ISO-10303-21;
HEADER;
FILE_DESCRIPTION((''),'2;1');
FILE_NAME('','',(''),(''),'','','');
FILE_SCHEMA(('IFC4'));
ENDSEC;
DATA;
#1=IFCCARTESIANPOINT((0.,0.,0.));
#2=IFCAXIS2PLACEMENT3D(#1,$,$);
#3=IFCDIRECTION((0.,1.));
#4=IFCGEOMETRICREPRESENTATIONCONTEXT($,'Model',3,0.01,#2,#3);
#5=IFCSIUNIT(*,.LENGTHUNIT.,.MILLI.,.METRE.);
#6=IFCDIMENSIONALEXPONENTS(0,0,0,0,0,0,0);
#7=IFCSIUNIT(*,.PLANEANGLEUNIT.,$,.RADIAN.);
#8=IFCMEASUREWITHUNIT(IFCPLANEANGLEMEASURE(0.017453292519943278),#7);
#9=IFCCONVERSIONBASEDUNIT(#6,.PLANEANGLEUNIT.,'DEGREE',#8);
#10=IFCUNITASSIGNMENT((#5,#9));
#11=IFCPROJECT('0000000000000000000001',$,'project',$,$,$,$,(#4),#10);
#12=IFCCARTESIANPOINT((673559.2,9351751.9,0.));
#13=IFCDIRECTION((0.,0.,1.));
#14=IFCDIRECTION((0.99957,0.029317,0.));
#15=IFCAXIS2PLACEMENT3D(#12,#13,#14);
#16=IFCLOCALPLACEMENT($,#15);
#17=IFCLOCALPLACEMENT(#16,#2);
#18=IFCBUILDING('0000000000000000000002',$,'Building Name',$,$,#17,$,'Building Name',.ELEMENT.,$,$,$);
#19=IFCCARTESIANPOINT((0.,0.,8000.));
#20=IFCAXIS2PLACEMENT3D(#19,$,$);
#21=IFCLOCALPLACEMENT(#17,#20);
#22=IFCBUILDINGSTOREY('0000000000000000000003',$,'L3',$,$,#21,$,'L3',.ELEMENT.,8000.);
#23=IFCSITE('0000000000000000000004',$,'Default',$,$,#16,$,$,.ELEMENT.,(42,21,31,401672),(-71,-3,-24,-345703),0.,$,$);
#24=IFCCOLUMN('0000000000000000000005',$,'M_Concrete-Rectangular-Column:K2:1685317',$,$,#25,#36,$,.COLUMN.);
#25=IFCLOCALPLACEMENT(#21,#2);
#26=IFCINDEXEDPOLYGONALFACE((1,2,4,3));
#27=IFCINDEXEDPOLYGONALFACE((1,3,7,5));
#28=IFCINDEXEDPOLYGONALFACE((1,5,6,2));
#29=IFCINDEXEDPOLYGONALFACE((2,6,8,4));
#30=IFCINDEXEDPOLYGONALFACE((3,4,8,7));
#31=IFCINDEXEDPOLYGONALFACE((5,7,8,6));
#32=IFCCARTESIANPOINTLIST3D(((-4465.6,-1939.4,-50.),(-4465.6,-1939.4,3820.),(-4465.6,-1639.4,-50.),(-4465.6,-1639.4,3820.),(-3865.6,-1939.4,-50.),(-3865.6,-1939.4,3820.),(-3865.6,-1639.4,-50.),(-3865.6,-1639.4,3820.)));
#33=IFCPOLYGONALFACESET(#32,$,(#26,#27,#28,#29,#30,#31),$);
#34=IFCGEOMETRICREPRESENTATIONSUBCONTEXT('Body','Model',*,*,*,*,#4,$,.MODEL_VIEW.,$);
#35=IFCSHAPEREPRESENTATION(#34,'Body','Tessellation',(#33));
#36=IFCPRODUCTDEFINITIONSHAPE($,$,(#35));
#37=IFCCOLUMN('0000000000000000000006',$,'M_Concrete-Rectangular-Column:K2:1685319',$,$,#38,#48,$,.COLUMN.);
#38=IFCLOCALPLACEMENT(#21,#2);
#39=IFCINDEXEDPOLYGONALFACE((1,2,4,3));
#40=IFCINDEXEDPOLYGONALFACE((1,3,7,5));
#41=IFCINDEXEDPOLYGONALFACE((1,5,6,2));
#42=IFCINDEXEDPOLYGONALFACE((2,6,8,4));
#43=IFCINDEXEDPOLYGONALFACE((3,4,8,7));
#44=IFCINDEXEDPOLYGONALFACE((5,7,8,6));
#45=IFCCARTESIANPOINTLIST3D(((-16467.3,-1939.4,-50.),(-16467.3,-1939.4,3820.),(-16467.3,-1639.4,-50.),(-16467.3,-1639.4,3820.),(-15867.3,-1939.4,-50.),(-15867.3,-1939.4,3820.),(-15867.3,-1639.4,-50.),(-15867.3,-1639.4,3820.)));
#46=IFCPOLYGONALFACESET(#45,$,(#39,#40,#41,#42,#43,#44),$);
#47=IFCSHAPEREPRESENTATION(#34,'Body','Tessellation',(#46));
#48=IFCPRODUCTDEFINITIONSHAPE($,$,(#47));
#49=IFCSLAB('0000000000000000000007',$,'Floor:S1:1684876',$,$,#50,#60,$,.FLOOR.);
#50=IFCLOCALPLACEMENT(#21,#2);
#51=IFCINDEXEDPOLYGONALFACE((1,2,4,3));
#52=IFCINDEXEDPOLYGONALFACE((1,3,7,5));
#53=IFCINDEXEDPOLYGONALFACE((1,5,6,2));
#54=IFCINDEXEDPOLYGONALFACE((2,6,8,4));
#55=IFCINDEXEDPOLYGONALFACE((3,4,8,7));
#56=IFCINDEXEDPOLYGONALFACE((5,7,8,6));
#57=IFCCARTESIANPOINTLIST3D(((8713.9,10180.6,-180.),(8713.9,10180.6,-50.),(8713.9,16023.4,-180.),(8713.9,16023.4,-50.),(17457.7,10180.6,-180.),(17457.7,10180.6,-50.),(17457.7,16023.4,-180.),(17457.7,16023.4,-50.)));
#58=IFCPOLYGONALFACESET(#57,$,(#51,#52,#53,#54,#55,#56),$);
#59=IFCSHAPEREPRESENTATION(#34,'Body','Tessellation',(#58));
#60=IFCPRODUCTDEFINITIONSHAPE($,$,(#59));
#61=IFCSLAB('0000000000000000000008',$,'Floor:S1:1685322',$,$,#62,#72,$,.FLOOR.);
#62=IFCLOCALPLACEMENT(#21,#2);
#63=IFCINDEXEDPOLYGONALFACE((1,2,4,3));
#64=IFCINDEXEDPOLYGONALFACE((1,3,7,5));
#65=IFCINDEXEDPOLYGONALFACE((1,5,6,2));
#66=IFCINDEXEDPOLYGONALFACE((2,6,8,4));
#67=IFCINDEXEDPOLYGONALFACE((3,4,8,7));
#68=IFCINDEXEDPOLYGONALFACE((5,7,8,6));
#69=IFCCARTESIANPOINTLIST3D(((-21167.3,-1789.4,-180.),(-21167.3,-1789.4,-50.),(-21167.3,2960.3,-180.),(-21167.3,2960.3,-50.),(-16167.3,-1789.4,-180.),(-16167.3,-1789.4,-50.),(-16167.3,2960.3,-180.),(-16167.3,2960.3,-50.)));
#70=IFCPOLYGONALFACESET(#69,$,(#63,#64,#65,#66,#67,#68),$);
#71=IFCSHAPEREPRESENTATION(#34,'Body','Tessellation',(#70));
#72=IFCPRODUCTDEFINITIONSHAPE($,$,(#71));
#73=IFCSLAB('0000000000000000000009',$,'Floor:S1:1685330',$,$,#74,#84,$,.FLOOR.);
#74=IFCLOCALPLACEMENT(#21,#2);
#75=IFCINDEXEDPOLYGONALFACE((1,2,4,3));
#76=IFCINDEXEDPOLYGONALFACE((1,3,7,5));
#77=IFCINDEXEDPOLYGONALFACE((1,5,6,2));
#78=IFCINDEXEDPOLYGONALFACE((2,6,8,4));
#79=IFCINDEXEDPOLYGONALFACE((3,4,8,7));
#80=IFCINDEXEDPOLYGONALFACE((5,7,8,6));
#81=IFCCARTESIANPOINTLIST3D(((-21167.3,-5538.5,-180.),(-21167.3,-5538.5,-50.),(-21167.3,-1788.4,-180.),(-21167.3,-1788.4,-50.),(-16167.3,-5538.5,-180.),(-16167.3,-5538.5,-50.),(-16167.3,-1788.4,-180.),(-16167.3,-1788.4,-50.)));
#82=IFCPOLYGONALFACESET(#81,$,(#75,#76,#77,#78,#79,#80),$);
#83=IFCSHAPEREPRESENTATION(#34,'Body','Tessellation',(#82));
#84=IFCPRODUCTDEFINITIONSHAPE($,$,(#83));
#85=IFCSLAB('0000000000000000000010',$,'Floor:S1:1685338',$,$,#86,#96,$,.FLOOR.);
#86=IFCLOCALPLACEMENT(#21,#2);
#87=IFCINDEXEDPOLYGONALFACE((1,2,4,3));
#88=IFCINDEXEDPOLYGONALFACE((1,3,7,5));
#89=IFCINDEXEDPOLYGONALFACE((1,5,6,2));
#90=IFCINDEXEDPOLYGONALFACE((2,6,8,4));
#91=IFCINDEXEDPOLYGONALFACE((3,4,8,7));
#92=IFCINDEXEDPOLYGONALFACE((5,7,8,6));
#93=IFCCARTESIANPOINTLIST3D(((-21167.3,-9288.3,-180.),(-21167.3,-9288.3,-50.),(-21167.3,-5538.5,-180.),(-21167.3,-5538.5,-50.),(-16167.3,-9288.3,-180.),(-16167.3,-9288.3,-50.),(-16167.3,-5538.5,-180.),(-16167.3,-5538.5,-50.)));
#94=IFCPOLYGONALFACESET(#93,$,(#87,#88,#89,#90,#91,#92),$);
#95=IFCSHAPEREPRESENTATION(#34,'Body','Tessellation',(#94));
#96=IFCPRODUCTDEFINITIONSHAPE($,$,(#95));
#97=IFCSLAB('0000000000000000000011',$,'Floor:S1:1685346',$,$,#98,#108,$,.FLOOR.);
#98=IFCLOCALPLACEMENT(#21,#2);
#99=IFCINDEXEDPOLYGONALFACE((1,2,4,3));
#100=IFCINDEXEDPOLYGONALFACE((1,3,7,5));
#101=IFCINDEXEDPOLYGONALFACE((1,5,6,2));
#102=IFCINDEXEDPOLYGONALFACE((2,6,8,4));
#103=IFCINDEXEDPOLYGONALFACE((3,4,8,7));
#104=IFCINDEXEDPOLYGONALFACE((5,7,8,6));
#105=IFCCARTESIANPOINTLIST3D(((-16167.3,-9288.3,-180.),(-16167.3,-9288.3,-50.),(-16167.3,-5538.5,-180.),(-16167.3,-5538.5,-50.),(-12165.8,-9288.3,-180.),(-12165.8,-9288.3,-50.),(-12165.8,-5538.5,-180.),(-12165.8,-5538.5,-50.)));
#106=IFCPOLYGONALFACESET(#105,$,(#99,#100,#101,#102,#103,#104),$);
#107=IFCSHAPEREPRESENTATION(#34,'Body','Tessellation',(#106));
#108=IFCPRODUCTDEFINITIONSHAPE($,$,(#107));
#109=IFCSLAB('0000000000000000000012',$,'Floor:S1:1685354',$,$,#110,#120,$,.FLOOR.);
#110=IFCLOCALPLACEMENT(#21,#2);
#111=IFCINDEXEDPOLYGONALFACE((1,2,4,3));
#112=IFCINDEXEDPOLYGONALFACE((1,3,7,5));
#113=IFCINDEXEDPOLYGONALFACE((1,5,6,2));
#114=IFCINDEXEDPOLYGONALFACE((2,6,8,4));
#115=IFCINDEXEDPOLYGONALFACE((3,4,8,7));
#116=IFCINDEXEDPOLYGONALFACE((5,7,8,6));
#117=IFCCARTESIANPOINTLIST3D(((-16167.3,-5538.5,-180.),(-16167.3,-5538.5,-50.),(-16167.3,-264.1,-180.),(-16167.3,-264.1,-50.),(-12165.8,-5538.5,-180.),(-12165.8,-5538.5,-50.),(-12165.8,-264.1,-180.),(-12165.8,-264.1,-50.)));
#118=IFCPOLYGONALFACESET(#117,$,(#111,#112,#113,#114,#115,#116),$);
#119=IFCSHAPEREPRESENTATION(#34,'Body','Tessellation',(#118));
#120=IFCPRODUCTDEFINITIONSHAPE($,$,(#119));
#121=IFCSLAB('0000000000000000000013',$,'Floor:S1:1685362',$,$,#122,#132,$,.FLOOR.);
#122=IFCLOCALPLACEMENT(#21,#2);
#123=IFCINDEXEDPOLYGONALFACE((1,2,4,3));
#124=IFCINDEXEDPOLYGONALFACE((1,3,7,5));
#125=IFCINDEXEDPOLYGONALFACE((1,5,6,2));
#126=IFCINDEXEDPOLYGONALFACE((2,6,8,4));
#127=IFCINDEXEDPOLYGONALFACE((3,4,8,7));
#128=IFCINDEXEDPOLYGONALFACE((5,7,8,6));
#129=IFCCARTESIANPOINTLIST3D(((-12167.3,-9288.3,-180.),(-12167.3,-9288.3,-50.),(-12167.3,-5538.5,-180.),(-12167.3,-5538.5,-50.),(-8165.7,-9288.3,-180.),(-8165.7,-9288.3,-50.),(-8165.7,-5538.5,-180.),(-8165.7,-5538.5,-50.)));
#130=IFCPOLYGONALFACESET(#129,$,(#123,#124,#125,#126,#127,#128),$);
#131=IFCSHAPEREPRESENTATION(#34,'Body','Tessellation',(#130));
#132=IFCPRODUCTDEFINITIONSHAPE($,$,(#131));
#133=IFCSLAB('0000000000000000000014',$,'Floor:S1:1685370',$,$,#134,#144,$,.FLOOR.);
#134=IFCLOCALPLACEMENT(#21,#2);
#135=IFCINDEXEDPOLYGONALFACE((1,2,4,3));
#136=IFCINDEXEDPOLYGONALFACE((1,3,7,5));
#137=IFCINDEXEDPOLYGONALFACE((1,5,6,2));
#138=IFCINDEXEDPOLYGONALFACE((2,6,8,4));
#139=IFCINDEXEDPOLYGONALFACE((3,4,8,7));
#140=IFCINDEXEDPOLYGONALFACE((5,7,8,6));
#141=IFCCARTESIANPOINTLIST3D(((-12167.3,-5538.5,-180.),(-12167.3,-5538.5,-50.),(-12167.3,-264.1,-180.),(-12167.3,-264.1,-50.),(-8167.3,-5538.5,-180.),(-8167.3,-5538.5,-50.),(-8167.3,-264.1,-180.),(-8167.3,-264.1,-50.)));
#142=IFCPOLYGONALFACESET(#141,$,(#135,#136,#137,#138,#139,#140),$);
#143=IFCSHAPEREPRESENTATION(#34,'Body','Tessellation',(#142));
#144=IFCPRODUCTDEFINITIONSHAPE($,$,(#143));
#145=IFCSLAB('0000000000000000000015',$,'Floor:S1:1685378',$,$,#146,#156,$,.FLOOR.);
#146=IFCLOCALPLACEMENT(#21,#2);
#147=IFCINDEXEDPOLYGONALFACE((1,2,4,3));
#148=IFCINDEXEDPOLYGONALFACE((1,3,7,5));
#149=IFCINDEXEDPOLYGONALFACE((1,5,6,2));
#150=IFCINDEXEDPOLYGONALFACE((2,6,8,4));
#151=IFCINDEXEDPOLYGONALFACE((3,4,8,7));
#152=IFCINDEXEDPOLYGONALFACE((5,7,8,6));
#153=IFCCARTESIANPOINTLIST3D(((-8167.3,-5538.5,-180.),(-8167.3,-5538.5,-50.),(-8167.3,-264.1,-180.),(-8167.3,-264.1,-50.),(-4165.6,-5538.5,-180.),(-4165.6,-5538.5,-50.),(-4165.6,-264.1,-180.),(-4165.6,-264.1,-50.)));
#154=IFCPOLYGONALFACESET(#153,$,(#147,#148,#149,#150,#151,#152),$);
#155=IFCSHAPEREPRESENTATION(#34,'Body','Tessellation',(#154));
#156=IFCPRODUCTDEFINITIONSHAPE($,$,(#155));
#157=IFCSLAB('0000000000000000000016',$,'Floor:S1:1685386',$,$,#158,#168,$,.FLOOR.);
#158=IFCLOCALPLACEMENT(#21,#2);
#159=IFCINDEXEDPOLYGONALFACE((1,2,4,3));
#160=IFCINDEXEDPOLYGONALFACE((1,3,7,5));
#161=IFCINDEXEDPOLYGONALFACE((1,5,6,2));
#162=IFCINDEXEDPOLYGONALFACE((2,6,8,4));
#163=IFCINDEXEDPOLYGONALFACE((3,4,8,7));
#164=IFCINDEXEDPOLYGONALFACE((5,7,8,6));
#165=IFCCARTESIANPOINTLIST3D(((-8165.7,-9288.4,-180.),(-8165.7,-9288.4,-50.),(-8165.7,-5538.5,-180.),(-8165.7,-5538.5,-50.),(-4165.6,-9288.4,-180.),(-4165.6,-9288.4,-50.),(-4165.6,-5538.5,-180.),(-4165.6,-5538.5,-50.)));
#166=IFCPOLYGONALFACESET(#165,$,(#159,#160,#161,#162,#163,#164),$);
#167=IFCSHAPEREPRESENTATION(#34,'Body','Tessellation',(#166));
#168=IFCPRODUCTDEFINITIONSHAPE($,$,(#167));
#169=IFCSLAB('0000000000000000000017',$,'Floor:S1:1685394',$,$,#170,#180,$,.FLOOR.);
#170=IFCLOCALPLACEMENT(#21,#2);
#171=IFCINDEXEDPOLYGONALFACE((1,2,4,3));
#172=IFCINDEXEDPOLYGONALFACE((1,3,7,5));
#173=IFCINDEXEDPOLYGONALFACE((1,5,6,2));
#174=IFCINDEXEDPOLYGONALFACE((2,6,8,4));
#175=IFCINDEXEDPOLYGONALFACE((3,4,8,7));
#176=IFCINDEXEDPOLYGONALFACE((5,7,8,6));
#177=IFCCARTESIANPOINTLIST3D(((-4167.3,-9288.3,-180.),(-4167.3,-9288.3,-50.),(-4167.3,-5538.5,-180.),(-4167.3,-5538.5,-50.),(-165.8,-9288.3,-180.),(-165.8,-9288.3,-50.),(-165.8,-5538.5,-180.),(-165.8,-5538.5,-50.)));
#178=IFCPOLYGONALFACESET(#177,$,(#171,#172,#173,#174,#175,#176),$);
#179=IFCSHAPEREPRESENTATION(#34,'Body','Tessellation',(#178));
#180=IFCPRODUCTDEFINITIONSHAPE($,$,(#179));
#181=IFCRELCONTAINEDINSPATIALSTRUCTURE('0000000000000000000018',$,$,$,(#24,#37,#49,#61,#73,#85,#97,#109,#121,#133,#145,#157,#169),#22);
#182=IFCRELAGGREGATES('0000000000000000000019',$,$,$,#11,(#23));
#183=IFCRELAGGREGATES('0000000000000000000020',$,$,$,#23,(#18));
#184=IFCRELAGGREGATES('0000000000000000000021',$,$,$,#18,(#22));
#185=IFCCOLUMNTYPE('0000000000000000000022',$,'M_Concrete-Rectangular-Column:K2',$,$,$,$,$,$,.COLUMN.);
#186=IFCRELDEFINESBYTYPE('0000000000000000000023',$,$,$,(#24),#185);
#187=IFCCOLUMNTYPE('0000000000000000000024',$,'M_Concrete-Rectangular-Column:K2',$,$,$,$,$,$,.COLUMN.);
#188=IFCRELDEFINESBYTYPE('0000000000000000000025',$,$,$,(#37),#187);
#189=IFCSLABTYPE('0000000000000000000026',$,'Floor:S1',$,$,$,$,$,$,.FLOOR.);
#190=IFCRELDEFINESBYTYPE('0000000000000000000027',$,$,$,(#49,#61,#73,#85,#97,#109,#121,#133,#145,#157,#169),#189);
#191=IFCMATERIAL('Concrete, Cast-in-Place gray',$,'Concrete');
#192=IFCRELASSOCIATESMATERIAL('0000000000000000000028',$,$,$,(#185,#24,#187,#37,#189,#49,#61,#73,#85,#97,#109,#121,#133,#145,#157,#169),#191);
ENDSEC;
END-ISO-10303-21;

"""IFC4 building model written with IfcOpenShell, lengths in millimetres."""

from ifc_helpers import new_model, entity, si_unit, converted_unit, direction, frame, origin, place, context, subcontext, project, spatial, indexed_curve, outline, extrude, source, transform, mapped, material, type_object, type_shapes, element, save


model = new_model("IFC4")

# Units and contexts
model_context = context("Model", 3, precision=0.01, world=origin(), true_north=direction((0.0, 1.0)))
body_context = subcontext(model_context, "Body", "Model", "MODEL_VIEW")
ifc_project = project(units=[si_unit("LENGTHUNIT", "METRE", prefix="MILLI"), converted_unit("PLANEANGLEUNIT", "DEGREE", entity("IfcPlaneAngleMeasure", 0.017453292519943278), si_unit("PLANEANGLEUNIT", "RADIAN"), dimensions=[0, 0, 0, 0, 0, 0, 0])], contexts=[model_context])

# Site, building, storey
site_placement = place(None, frame((673559.2, 9351751.9, 0.0), z_axis=(0.0, 0.0, 1.0), x_axis=(0.99957, 0.029317, 0.0)))
site = spatial("IfcSite", under=ifc_project, at=site_placement, Name="Default", CompositionType="ELEMENT", RefLatitude=(42, 21, 31, 401672), RefLongitude=(-71, -3, -24, -345703), RefElevation=0.0)
building_placement = place(site_placement, origin())
building = spatial("IfcBuilding", under=site, at=building_placement, Name="Building Name", LongName="Building Name", CompositionType="ELEMENT")
storey_placement = place(building_placement, frame((0.0, 0.0, 8000.0)))
storey = spatial("IfcBuildingStorey", under=building, at=storey_placement, Name="L3", LongName="L3", CompositionType="ELEMENT", Elevation=8000.0)

# Columns
ifc_material = material(Name="Concrete, Cast-in-Place gray", Category="Concrete")
column_type_1 = type_object("IfcColumnType", Name="M_Concrete-Rectangular-Column:K2", PredefinedType="COLUMN", material=ifc_material)
shared_shape_1 = source(origin(), body_context, "Body", "SweptSolid", [
    extrude(outline(indexed_curve([(-150.0, -300.0), (150.0, -300.0), (150.0, 300.0), (-150.0, 300.0), (-150.0, -300.0)], self_intersect=False)), frame((-4165.6, -1789.4, 7950.0), z_axis=(0.0, 0.0, 1.0), x_axis=(0.0, -1.0, 0.0)), (0.0, 0.0, 1.0), 3870.0),
])
type_shapes(column_type_1, [shared_shape_1])
column_1_placement = place(storey_placement, frame((0.0, 0.0, -8000.0)))
element("IfcColumn", 1, at=column_1_placement, inside=storey, type_object=column_type_1, material=ifc_material, Name="M_Concrete-Rectangular-Column:K2:1685317", PredefinedType="COLUMN", context=body_context, shape_type="MappedRepresentation", body=[
    mapped(shared_shape_1, transform((0.0, 0.0, 0.0), scale=1.0)),
])
column_type_2 = type_object("IfcColumnType", Name="M_Concrete-Rectangular-Column:K2", PredefinedType="COLUMN", material=ifc_material)
shared_shape_2 = source(origin(), body_context, "Body", "SweptSolid", [
    extrude(outline(indexed_curve([(-150.0, -300.0), (150.0, -300.0), (150.0, 300.0), (-150.0, 300.0), (-150.0, -300.0)], self_intersect=False)), frame((-16167.3, -1789.4, 7950.0), z_axis=(0.0, 0.0, 1.0), x_axis=(0.0, -1.0, 0.0)), (0.0, 0.0, 1.0), 3870.0),
])
type_shapes(column_type_2, [shared_shape_2])
column_2_placement = place(storey_placement, frame((0.0, 0.0, -8000.0)))
element("IfcColumn", 2, at=column_2_placement, inside=storey, type_object=column_type_2, material=ifc_material, Name="M_Concrete-Rectangular-Column:K2:1685319", PredefinedType="COLUMN", context=body_context, shape_type="MappedRepresentation", body=[
    mapped(shared_shape_2, transform((0.0, 0.0, 0.0), scale=1.0)),
])

# Slabs
slab_type_1 = type_object("IfcSlabType", Name="Floor:S1", PredefinedType="FLOOR", material=ifc_material)
slab_1_placement = place(storey_placement, origin())
element("IfcSlab", 3, at=slab_1_placement, inside=storey, type_object=slab_type_1, material=ifc_material, Name="Floor:S1:1684876", PredefinedType="FLOOR", context=body_context, shape_type="SweptSolid", body=[
    extrude(outline(indexed_curve([(-2921.4, -4371.9), (2921.4, -4371.9), (2921.4, 4371.9), (-2921.4, 4371.9), (-2921.4, -4371.9)], self_intersect=False)), frame((13085.8, 13102.0, -50.0), z_axis=(0.0, 0.0, -1.0), x_axis=(0.0, 1.0, 0.0)), (0.0, 0.0, 1.0), 130.0),
])
slab_2_placement = place(storey_placement, origin())
element("IfcSlab", 4, at=slab_2_placement, inside=storey, type_object=slab_type_1, material=ifc_material, Name="Floor:S1:1685322", PredefinedType="FLOOR", context=body_context, shape_type="SweptSolid", body=[
    extrude(outline(indexed_curve([(-2374.9, -2500.0), (2374.9, -2500.0), (2374.9, 2500.0), (-2374.9, 2500.0), (-2374.9, -2500.0)], self_intersect=False)), frame((-18667.3, 585.4, -50.0), z_axis=(0.0, 0.0, -1.0), x_axis=(0.0, 1.0, 0.0)), (0.0, 0.0, 1.0), 130.0),
])
slab_3_placement = place(storey_placement, origin())
element("IfcSlab", 5, at=slab_3_placement, inside=storey, type_object=slab_type_1, material=ifc_material, Name="Floor:S1:1685330", PredefinedType="FLOOR", context=body_context, shape_type="SweptSolid", body=[
    extrude(outline(indexed_curve([(-1875.1, -2500.0), (1875.1, -2500.0), (1875.1, 2500.0), (-1875.1, 2500.0), (-1875.1, -2500.0)], self_intersect=False)), frame((-18667.3, -3663.5, -50.0), z_axis=(0.0, 0.0, -1.0), x_axis=(0.0, 1.0, 0.0)), (0.0, 0.0, 1.0), 130.0),
])
slab_4_placement = place(storey_placement, origin())
element("IfcSlab", 6, at=slab_4_placement, inside=storey, type_object=slab_type_1, material=ifc_material, Name="Floor:S1:1685338", PredefinedType="FLOOR", context=body_context, shape_type="SweptSolid", body=[
    extrude(outline(indexed_curve([(-1874.9, -2500.0), (1874.9, -2500.0), (1874.9, 2500.0), (-1874.9, 2500.0), (-1874.9, -2500.0)], self_intersect=False)), frame((-18667.3, -7413.4, -50.0), z_axis=(0.0, 0.0, -1.0), x_axis=(0.0, 1.0, 0.0)), (0.0, 0.0, 1.0), 130.0),
])
slab_5_placement = place(storey_placement, origin())
element("IfcSlab", 7, at=slab_5_placement, inside=storey, type_object=slab_type_1, material=ifc_material, Name="Floor:S1:1685346", PredefinedType="FLOOR", context=body_context, shape_type="SweptSolid", body=[
    extrude(outline(indexed_curve([(-1874.9, -2000.8), (1874.9, -2000.8), (1874.9, 2000.8), (-1874.9, 2000.8), (-1874.9, -2000.8)], self_intersect=False)), frame((-14166.6, -7413.4, -50.0), z_axis=(0.0, 0.0, -1.0), x_axis=(0.0, 1.0, 0.0)), (0.0, 0.0, 1.0), 130.0),
])
slab_6_placement = place(storey_placement, origin())
element("IfcSlab", 8, at=slab_6_placement, inside=storey, type_object=slab_type_1, material=ifc_material, Name="Floor:S1:1685354", PredefinedType="FLOOR", context=body_context, shape_type="SweptSolid", body=[
    extrude(outline(indexed_curve([(-2637.2, -2000.8), (2637.2, -2000.8), (2637.2, 2000.8), (-2637.2, 2000.8), (-2637.2, -2000.8)], self_intersect=False)), frame((-14166.6, -2901.3, -50.0), z_axis=(0.0, 0.0, -1.0), x_axis=(0.0, 1.0, 0.0)), (0.0, 0.0, 1.0), 130.0),
])
slab_7_placement = place(storey_placement, origin())
element("IfcSlab", 9, at=slab_7_placement, inside=storey, type_object=slab_type_1, material=ifc_material, Name="Floor:S1:1685362", PredefinedType="FLOOR", context=body_context, shape_type="SweptSolid", body=[
    extrude(outline(indexed_curve([(-1874.9, -2000.8), (1874.9, -2000.8), (1874.9, 2000.8), (-1874.9, 2000.8), (-1874.9, -2000.8)], self_intersect=False)), frame((-10166.5, -7413.4, -50.0), z_axis=(0.0, 0.0, -1.0), x_axis=(0.0, 1.0, 0.0)), (0.0, 0.0, 1.0), 130.0),
])
slab_8_placement = place(storey_placement, origin())
element("IfcSlab", 10, at=slab_8_placement, inside=storey, type_object=slab_type_1, material=ifc_material, Name="Floor:S1:1685370", PredefinedType="FLOOR", context=body_context, shape_type="SweptSolid", body=[
    extrude(outline(indexed_curve([(-2637.2, -2000.0), (2637.2, -2000.0), (2637.2, 2000.0), (-2637.2, 2000.0), (-2637.2, -2000.0)], self_intersect=False)), frame((-10167.3, -2901.3, -50.0), z_axis=(0.0, 0.0, -1.0), x_axis=(0.0, 1.0, 0.0)), (0.0, 0.0, 1.0), 130.0),
])
slab_9_placement = place(storey_placement, origin())
element("IfcSlab", 11, at=slab_9_placement, inside=storey, type_object=slab_type_1, material=ifc_material, Name="Floor:S1:1685378", PredefinedType="FLOOR", context=body_context, shape_type="SweptSolid", body=[
    extrude(outline(indexed_curve([(-2637.2, -2000.9), (2637.2, -2000.9), (2637.2, 2000.9), (-2637.2, 2000.9), (-2637.2, -2000.9)], self_intersect=False)), frame((-6166.4, -2901.3, -50.0), z_axis=(0.0, 0.0, -1.0), x_axis=(0.0, 1.0, 0.0)), (0.0, 0.0, 1.0), 130.0),
])
slab_10_placement = place(storey_placement, origin())
element("IfcSlab", 12, at=slab_10_placement, inside=storey, type_object=slab_type_1, material=ifc_material, Name="Floor:S1:1685386", PredefinedType="FLOOR", context=body_context, shape_type="SweptSolid", body=[
    extrude(outline(indexed_curve([(-1874.9, -2000.1), (1874.9, -2000.1), (1874.9, 2000.1), (-1874.9, 2000.1), (-1874.9, -2000.1)], self_intersect=False)), frame((-6165.6, -7413.5, -50.0), z_axis=(0.0, 0.0, -1.0), x_axis=(0.0, 1.0, 0.0)), (0.0, 0.0, 1.0), 130.0),
])
slab_11_placement = place(storey_placement, origin())
element("IfcSlab", 13, at=slab_11_placement, inside=storey, type_object=slab_type_1, material=ifc_material, Name="Floor:S1:1685394", PredefinedType="FLOOR", context=body_context, shape_type="SweptSolid", body=[
    extrude(outline(indexed_curve([(-1874.9, -2000.8), (1874.9, -2000.8), (1874.9, 2000.8), (-1874.9, 2000.8), (-1874.9, -2000.8)], self_intersect=False)), frame((-2166.6, -7413.4, -50.0), z_axis=(0.0, 0.0, -1.0), x_axis=(0.0, 1.0, 0.0)), (0.0, 0.0, 1.0), 130.0),
])

save(model, "model.ifc")
